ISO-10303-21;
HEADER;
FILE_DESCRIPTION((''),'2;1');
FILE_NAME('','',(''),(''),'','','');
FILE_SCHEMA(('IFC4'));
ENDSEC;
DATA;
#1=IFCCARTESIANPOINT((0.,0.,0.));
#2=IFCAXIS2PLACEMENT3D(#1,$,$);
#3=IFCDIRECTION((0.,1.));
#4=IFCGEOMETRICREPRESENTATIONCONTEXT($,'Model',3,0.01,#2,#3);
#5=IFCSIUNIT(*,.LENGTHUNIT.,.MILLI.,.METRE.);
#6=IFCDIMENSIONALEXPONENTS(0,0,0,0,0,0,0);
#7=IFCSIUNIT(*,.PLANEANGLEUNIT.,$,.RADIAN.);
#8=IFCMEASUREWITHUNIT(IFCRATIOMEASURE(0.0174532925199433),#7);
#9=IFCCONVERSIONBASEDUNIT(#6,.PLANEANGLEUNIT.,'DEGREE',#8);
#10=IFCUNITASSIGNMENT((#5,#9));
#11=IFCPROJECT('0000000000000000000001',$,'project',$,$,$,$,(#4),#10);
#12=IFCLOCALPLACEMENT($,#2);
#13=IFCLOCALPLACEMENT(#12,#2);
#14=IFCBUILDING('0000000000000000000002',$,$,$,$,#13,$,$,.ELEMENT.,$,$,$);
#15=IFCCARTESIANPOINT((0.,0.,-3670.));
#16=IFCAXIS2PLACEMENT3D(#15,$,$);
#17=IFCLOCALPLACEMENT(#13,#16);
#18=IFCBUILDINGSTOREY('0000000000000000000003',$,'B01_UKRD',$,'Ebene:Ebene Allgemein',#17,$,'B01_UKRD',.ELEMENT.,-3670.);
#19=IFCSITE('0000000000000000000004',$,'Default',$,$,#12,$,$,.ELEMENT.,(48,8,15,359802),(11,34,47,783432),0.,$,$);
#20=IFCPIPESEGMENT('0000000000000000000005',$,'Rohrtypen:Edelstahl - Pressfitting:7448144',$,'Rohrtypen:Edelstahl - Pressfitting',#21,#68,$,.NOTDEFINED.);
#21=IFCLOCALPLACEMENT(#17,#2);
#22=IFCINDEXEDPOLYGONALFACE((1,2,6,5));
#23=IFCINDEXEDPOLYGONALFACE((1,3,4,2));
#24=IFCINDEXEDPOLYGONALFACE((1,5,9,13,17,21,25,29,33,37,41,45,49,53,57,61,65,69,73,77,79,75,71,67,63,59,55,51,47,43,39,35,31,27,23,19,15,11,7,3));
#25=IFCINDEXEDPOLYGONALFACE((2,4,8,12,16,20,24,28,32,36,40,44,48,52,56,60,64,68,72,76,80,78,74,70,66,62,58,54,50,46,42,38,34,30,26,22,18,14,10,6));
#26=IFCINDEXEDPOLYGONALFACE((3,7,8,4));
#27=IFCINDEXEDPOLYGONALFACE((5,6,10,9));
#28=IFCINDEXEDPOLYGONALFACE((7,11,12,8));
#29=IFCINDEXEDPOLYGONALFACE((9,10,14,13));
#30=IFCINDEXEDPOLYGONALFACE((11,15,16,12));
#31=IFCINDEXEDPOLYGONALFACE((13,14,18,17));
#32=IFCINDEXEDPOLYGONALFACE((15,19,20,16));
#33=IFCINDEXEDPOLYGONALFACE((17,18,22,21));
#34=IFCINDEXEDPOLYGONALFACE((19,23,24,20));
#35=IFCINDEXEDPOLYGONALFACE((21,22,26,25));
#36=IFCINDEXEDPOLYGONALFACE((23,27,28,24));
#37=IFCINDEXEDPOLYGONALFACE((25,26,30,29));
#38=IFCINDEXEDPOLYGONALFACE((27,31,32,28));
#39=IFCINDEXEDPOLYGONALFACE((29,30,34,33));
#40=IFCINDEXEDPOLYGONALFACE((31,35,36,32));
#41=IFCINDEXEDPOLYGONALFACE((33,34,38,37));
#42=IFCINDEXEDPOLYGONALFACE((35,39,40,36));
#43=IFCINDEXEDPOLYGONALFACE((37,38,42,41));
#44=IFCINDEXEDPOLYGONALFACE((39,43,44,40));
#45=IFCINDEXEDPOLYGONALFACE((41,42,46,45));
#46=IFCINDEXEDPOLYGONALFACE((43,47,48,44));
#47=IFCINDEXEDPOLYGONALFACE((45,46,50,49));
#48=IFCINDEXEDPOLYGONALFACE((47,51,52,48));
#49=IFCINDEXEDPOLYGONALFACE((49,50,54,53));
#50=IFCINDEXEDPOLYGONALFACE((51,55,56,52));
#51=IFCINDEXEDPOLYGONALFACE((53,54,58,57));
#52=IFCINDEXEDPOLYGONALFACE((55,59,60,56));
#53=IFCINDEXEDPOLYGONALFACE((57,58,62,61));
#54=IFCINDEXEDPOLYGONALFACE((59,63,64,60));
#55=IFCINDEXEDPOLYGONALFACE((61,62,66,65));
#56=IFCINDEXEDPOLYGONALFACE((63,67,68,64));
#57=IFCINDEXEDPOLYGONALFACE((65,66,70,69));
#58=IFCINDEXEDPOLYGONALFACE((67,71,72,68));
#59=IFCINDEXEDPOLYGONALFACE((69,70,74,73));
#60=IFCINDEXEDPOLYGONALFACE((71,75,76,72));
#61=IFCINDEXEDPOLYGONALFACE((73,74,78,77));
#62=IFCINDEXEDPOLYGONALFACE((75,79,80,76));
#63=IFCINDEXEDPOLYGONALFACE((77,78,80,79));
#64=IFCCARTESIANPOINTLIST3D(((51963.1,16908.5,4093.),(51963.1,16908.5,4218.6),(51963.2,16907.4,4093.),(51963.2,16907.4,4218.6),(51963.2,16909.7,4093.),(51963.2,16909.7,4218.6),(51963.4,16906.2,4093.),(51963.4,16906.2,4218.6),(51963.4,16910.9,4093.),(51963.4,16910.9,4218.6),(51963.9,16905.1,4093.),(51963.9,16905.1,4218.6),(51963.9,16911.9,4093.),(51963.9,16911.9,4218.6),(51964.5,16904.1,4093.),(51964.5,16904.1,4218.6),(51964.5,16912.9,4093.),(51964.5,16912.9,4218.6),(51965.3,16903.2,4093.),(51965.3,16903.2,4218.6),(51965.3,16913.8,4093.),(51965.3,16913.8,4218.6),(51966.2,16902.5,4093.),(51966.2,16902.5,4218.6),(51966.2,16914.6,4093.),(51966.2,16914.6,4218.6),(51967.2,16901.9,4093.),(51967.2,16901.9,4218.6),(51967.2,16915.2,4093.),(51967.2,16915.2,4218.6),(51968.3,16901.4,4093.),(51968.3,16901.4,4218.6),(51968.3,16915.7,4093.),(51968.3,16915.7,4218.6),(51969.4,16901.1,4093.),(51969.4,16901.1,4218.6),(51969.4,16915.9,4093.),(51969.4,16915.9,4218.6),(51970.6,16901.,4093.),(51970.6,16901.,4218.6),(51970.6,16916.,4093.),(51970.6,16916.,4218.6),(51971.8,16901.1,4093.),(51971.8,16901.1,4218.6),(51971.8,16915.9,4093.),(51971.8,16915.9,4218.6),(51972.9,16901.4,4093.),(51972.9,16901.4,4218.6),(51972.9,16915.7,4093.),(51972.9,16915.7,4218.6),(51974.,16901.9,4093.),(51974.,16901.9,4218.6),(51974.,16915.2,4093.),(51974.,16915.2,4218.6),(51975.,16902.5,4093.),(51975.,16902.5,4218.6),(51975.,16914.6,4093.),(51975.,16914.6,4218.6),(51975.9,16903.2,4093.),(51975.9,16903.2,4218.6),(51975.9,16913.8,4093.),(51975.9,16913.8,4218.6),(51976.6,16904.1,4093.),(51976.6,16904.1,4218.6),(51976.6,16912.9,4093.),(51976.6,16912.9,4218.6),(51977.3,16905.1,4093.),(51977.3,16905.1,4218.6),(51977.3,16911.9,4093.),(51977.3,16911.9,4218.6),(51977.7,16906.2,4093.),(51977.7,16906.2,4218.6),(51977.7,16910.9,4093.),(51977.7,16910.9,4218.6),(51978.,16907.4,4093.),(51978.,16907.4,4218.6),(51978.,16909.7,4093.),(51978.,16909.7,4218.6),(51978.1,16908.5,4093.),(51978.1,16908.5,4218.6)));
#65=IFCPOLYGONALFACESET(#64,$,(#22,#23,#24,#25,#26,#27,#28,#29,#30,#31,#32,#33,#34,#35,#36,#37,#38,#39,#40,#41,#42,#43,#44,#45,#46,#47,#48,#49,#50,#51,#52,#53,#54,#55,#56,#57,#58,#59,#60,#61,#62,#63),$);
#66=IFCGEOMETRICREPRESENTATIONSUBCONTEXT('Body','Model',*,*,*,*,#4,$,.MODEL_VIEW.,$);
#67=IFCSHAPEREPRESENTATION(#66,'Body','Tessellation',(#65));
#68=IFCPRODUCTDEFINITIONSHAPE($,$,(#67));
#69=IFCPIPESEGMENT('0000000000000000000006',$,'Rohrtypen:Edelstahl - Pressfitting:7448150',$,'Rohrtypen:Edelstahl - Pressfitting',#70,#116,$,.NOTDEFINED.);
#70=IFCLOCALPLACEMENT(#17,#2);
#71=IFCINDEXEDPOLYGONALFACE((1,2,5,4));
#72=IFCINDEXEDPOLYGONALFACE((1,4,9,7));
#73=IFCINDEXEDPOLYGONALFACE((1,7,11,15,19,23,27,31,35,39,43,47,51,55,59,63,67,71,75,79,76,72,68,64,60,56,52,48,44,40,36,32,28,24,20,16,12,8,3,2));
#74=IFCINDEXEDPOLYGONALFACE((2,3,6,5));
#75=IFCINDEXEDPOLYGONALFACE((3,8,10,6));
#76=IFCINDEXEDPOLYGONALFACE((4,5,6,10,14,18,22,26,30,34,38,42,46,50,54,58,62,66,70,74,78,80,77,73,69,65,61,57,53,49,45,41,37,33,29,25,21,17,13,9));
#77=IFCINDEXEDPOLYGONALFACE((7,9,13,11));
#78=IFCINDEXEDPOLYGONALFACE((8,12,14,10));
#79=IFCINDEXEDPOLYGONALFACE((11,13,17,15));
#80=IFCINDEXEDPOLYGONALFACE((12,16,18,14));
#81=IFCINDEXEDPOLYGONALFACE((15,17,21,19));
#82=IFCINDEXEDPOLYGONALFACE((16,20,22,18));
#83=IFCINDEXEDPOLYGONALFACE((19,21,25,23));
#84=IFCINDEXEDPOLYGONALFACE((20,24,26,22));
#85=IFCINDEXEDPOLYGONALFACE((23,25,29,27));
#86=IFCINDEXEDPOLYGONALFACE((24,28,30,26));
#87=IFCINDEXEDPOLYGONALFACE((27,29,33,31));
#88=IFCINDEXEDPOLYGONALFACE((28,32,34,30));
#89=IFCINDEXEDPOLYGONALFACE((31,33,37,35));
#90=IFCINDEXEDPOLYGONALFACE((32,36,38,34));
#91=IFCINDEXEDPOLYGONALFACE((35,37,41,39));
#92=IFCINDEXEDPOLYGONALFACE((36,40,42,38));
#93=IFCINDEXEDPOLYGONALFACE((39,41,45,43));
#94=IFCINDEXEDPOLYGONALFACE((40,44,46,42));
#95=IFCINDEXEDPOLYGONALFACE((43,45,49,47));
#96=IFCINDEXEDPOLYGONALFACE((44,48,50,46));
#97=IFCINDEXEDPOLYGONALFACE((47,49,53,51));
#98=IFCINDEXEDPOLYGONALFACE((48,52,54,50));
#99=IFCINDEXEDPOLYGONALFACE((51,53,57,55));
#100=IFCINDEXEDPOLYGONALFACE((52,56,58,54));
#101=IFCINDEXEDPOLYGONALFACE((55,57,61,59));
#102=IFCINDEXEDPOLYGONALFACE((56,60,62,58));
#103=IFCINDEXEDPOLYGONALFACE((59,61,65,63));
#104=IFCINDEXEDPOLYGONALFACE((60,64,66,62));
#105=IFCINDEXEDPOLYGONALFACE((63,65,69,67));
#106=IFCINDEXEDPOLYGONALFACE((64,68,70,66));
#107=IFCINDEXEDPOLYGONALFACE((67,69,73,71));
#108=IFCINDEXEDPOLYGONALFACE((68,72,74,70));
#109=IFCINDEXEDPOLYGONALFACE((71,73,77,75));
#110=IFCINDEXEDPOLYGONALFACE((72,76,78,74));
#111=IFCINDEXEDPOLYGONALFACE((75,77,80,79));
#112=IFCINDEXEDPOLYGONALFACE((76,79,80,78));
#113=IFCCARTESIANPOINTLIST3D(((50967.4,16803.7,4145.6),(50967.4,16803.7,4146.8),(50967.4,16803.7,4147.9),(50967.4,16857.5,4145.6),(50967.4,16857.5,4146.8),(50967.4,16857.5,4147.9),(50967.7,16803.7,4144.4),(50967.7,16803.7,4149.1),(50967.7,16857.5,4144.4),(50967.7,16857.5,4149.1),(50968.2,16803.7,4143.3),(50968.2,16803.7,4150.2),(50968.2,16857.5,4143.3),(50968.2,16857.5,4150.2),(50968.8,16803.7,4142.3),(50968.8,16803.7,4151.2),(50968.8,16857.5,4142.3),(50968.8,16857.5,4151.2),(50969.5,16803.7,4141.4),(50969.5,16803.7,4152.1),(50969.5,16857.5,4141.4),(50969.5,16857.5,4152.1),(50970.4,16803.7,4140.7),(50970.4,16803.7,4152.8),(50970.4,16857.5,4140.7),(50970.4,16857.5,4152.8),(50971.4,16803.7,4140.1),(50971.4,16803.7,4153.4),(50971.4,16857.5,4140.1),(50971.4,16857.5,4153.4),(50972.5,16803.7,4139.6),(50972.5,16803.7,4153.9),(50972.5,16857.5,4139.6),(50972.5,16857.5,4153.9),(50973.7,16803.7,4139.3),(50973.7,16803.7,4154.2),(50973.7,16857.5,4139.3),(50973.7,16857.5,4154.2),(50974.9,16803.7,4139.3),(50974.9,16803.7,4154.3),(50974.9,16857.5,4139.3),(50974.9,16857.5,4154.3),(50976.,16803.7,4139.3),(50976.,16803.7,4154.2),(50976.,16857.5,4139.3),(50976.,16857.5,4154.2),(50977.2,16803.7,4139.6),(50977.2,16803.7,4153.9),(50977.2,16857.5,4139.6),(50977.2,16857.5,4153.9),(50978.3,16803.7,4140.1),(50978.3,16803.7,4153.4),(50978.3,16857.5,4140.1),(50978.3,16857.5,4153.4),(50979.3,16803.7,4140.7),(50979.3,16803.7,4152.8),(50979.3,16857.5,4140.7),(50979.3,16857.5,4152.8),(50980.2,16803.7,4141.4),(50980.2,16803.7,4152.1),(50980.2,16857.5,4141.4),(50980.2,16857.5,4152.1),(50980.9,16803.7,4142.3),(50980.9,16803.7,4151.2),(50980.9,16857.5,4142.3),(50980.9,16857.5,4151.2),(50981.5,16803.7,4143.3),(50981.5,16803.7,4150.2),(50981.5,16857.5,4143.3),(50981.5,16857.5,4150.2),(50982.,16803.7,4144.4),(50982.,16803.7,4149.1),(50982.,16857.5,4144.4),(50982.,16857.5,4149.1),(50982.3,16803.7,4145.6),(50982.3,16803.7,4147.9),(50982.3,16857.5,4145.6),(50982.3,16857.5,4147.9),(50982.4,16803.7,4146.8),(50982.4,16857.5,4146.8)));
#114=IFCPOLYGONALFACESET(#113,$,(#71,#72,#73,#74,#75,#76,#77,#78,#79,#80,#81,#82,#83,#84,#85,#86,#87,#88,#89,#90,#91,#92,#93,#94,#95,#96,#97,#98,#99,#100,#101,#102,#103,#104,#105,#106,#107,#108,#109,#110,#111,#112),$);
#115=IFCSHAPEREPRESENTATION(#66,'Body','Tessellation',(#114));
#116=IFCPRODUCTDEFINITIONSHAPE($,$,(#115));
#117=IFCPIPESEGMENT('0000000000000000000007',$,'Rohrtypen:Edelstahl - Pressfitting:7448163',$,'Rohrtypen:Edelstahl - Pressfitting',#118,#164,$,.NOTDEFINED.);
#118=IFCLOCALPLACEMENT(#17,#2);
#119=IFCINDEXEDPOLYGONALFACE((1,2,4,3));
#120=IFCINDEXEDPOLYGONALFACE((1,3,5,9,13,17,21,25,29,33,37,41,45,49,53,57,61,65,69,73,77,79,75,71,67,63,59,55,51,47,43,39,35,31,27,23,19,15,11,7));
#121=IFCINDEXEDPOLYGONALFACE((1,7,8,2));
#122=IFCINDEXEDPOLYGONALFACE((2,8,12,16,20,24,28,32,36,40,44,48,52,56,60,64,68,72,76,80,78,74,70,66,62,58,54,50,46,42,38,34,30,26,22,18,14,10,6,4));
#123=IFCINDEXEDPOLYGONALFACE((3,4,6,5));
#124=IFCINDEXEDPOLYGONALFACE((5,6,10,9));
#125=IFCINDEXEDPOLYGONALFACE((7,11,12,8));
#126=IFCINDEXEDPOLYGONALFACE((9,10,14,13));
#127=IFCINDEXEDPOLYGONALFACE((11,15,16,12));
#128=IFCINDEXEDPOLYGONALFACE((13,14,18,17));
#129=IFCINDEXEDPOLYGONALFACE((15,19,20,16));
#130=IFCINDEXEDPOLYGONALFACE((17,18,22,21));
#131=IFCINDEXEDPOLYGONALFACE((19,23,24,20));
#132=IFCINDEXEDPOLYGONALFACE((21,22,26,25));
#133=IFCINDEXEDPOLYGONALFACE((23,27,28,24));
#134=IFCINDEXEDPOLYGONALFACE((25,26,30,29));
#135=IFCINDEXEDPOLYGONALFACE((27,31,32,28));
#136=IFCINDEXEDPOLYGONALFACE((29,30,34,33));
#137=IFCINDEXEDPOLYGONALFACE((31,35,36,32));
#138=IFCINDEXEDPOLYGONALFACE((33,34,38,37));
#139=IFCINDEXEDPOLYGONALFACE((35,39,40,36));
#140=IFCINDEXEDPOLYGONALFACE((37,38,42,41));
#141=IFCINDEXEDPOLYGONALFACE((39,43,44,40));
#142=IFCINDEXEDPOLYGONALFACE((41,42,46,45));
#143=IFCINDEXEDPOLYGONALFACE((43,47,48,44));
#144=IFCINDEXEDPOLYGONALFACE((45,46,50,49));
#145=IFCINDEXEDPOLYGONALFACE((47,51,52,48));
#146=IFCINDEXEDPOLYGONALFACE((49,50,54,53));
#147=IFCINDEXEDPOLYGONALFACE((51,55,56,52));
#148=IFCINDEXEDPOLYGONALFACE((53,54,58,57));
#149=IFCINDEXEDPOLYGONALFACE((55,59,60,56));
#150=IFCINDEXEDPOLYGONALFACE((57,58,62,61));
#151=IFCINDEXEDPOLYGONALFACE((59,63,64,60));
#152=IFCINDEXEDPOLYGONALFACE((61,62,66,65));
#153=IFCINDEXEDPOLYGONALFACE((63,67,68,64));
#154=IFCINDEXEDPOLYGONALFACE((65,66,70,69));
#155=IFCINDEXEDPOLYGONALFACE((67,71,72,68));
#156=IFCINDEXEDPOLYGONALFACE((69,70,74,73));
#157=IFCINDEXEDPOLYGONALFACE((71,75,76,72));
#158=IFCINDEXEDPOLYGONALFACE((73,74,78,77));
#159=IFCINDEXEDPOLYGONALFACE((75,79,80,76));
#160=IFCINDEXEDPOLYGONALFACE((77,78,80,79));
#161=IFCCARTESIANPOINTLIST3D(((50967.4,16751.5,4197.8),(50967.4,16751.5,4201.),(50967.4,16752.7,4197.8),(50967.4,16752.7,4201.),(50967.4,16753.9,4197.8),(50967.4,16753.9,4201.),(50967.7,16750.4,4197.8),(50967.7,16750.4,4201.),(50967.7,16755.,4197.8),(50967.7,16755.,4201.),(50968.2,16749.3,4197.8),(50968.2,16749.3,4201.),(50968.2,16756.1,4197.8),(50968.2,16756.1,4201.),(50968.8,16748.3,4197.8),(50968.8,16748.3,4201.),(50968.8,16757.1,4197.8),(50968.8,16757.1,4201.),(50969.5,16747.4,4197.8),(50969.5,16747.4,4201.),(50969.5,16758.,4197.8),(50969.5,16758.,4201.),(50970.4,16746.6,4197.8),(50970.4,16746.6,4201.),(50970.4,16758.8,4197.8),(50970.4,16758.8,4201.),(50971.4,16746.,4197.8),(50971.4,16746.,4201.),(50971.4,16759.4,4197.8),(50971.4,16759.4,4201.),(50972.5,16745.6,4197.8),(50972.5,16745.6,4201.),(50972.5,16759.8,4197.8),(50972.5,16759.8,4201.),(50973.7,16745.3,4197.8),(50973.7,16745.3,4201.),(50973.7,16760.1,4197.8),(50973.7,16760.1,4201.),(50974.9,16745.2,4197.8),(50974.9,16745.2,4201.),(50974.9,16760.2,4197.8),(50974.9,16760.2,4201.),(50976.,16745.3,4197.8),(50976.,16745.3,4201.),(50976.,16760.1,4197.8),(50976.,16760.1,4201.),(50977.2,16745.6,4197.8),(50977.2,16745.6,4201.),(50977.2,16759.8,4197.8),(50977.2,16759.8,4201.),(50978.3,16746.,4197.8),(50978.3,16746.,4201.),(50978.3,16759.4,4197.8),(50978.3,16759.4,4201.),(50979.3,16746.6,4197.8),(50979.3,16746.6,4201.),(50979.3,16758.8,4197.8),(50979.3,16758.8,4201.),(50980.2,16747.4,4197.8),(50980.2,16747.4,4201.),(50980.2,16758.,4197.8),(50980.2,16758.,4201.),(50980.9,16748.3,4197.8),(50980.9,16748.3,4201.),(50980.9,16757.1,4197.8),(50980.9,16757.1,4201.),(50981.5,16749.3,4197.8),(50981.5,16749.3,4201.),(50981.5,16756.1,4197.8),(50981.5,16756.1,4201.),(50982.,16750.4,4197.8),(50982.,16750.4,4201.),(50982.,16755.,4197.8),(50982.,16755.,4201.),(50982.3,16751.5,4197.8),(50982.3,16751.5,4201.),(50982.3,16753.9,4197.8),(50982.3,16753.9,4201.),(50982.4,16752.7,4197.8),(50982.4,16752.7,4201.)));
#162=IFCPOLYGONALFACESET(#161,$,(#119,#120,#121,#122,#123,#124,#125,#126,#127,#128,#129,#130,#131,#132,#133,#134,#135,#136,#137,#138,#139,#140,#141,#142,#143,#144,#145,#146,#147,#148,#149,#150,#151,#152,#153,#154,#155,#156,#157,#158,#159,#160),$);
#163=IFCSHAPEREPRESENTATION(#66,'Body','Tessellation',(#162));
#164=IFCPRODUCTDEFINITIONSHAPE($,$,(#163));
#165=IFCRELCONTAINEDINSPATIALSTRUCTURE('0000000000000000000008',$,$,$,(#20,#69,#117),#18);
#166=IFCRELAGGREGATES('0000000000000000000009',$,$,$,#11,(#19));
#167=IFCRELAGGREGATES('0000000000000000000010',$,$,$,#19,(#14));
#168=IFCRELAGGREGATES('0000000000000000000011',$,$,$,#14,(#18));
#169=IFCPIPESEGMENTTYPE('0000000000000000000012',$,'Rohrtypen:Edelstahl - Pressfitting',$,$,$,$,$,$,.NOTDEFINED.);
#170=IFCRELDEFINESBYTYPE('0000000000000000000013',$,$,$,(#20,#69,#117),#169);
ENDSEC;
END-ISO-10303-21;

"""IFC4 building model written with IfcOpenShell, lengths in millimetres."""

from ifc_helpers import new_model, entity, si_unit, converted_unit, direction, frame, origin, place, context, subcontext, project, spatial, indexed_curve, outline, extrude, type_object, element, save


model = new_model("IFC4")

# Units and contexts
model_context = context("Model", 3, precision=0.01, world=origin(), true_north=direction((0.0, 1.0)))
body_context = subcontext(model_context, "Body", "Model", "MODEL_VIEW")
ifc_project = project(units=[si_unit("LENGTHUNIT", "METRE", prefix="MILLI"), converted_unit("PLANEANGLEUNIT", "DEGREE", entity("IfcRatioMeasure", 0.0174532925199433), si_unit("PLANEANGLEUNIT", "RADIAN"), dimensions=[0, 0, 0, 0, 0, 0, 0])], contexts=[model_context])

# Site, building, storey
site_placement = place(None, origin())
site = spatial("IfcSite", under=ifc_project, at=site_placement, Name="Default", CompositionType="ELEMENT", RefLatitude=(48, 8, 15, 359802), RefLongitude=(11, 34, 47, 783432), RefElevation=0.0)
building_placement = place(site_placement, origin())
building = spatial("IfcBuilding", under=site, at=building_placement, CompositionType="ELEMENT")
storey_placement = place(building_placement, frame((0.0, 0.0, -3670.0)))
storey = spatial("IfcBuildingStorey", under=building, at=storey_placement, Name="B01_UKRD", ObjectType="Ebene:Ebene Allgemein", LongName="B01_UKRD", CompositionType="ELEMENT", Elevation=-3670.0)

# Pipe segments
pipe_segment_type = type_object("IfcPipeSegmentType", Name="Rohrtypen:Edelstahl - Pressfitting", PredefinedType="NOTDEFINED")
pipe_segment_1_placement = place(storey_placement, origin())
element("IfcPipeSegment", 1, at=pipe_segment_1_placement, inside=storey, type_object=pipe_segment_type, Name="Rohrtypen:Edelstahl - Pressfitting:7448144", ObjectType="Rohrtypen:Edelstahl - Pressfitting", PredefinedType="NOTDEFINED", context=body_context, shape_type="SweptSolid", body=[
    extrude(outline(indexed_curve([(7.5, 0.0), (7.4, 1.2), (7.1, 2.3), (6.7, 3.4), (6.1, 4.4), (5.3, 5.3), (4.4, 6.1), (3.4, 6.7), (2.3, 7.1), (1.2, 7.4), (0.0, 7.5), (-1.2, 7.4), (-2.3, 7.1), (-3.4, 6.7), (-4.4, 6.1), (-5.3, 5.3), (-6.1, 4.4), (-6.7, 3.4), (-7.1, 2.3), (-7.4, 1.2), (-7.5, 0.0), (-7.4, -1.2), (-7.1, -2.3), (-6.7, -3.4), (-6.1, -4.4), (-5.3, -5.3), (-4.4, -6.1), (-3.4, -6.7), (-2.3, -7.1), (-1.2, -7.4), (0.0, -7.5), (1.2, -7.4), (2.3, -7.1), (3.4, -6.7), (4.4, -6.1), (5.3, -5.3), (6.1, -4.4), (6.7, -3.4), (7.1, -2.3), (7.4, -1.2), (7.5, 0.0)], self_intersect=False)), frame((51970.6, 16908.5, 4093.0), z_axis=(0.0, 0.0, 1.0), x_axis=(-1.0, 0.0, 0.0)), (0.0, 0.0, 1.0), 125.6),
])
pipe_segment_2_placement = place(storey_placement, origin())
element("IfcPipeSegment", 2, at=pipe_segment_2_placement, inside=storey, type_object=pipe_segment_type, Name="Rohrtypen:Edelstahl - Pressfitting:7448150", ObjectType="Rohrtypen:Edelstahl - Pressfitting", PredefinedType="NOTDEFINED", context=body_context, shape_type="SweptSolid", body=[
    extrude(outline(indexed_curve([(7.5, 0.0), (7.4, 1.2), (7.1, 2.3), (6.7, 3.4), (6.1, 4.4), (5.3, 5.3), (4.4, 6.1), (3.4, 6.7), (2.3, 7.1), (1.2, 7.4), (0.0, 7.5), (-1.2, 7.4), (-2.3, 7.1), (-3.4, 6.7), (-4.4, 6.1), (-5.3, 5.3), (-6.1, 4.4), (-6.7, 3.4), (-7.1, 2.3), (-7.4, 1.2), (-7.5, 0.0), (-7.4, -1.2), (-7.1, -2.3), (-6.7, -3.4), (-6.1, -4.4), (-5.3, -5.3), (-4.4, -6.1), (-3.4, -6.7), (-2.3, -7.1), (-1.2, -7.4), (0.0, -7.5), (1.2, -7.4), (2.3, -7.1), (3.4, -6.7), (4.4, -6.1), (5.3, -5.3), (6.1, -4.4), (6.7, -3.4), (7.1, -2.3), (7.4, -1.2), (7.5, 0.0)], self_intersect=False)), frame((50974.9, 16803.7, 4146.8), z_axis=(0.000008, 1.0, 0.0), x_axis=(-1.0, 0.000008, 0.0)), (0.0, 0.0, 1.0), 53.8),
])
pipe_segment_3_placement = place(storey_placement, origin())
element("IfcPipeSegment", 3, at=pipe_segment_3_placement, inside=storey, type_object=pipe_segment_type, Name="Rohrtypen:Edelstahl - Pressfitting:7448163", ObjectType="Rohrtypen:Edelstahl - Pressfitting", PredefinedType="NOTDEFINED", context=body_context, shape_type="SweptSolid", body=[
    extrude(outline(indexed_curve([(7.5, 0.0), (7.4, 1.2), (7.1, 2.3), (6.7, 3.4), (6.1, 4.4), (5.3, 5.3), (4.4, 6.1), (3.4, 6.7), (2.3, 7.1), (1.2, 7.4), (0.0, 7.5), (-1.2, 7.4), (-2.3, 7.1), (-3.4, 6.7), (-4.4, 6.1), (-5.3, 5.3), (-6.1, 4.4), (-6.7, 3.4), (-7.1, 2.3), (-7.4, 1.2), (-7.5, 0.0), (-7.4, -1.2), (-7.1, -2.3), (-6.7, -3.4), (-6.1, -4.4), (-5.3, -5.3), (-4.4, -6.1), (-3.4, -6.7), (-2.3, -7.1), (-1.2, -7.4), (0.0, -7.5), (1.2, -7.4), (2.3, -7.1), (3.4, -6.7), (4.4, -6.1), (5.3, -5.3), (6.1, -4.4), (6.7, -3.4), (7.1, -2.3), (7.4, -1.2), (7.5, 0.0)], self_intersect=False)), frame((50974.9, 16752.7, 4197.8), z_axis=(0.0, 0.0, 1.0), x_axis=(-1.0, 0.0, 0.0)), (0.0, 0.0, 1.0), 3.2),
])

save(model, "model.ifc")
